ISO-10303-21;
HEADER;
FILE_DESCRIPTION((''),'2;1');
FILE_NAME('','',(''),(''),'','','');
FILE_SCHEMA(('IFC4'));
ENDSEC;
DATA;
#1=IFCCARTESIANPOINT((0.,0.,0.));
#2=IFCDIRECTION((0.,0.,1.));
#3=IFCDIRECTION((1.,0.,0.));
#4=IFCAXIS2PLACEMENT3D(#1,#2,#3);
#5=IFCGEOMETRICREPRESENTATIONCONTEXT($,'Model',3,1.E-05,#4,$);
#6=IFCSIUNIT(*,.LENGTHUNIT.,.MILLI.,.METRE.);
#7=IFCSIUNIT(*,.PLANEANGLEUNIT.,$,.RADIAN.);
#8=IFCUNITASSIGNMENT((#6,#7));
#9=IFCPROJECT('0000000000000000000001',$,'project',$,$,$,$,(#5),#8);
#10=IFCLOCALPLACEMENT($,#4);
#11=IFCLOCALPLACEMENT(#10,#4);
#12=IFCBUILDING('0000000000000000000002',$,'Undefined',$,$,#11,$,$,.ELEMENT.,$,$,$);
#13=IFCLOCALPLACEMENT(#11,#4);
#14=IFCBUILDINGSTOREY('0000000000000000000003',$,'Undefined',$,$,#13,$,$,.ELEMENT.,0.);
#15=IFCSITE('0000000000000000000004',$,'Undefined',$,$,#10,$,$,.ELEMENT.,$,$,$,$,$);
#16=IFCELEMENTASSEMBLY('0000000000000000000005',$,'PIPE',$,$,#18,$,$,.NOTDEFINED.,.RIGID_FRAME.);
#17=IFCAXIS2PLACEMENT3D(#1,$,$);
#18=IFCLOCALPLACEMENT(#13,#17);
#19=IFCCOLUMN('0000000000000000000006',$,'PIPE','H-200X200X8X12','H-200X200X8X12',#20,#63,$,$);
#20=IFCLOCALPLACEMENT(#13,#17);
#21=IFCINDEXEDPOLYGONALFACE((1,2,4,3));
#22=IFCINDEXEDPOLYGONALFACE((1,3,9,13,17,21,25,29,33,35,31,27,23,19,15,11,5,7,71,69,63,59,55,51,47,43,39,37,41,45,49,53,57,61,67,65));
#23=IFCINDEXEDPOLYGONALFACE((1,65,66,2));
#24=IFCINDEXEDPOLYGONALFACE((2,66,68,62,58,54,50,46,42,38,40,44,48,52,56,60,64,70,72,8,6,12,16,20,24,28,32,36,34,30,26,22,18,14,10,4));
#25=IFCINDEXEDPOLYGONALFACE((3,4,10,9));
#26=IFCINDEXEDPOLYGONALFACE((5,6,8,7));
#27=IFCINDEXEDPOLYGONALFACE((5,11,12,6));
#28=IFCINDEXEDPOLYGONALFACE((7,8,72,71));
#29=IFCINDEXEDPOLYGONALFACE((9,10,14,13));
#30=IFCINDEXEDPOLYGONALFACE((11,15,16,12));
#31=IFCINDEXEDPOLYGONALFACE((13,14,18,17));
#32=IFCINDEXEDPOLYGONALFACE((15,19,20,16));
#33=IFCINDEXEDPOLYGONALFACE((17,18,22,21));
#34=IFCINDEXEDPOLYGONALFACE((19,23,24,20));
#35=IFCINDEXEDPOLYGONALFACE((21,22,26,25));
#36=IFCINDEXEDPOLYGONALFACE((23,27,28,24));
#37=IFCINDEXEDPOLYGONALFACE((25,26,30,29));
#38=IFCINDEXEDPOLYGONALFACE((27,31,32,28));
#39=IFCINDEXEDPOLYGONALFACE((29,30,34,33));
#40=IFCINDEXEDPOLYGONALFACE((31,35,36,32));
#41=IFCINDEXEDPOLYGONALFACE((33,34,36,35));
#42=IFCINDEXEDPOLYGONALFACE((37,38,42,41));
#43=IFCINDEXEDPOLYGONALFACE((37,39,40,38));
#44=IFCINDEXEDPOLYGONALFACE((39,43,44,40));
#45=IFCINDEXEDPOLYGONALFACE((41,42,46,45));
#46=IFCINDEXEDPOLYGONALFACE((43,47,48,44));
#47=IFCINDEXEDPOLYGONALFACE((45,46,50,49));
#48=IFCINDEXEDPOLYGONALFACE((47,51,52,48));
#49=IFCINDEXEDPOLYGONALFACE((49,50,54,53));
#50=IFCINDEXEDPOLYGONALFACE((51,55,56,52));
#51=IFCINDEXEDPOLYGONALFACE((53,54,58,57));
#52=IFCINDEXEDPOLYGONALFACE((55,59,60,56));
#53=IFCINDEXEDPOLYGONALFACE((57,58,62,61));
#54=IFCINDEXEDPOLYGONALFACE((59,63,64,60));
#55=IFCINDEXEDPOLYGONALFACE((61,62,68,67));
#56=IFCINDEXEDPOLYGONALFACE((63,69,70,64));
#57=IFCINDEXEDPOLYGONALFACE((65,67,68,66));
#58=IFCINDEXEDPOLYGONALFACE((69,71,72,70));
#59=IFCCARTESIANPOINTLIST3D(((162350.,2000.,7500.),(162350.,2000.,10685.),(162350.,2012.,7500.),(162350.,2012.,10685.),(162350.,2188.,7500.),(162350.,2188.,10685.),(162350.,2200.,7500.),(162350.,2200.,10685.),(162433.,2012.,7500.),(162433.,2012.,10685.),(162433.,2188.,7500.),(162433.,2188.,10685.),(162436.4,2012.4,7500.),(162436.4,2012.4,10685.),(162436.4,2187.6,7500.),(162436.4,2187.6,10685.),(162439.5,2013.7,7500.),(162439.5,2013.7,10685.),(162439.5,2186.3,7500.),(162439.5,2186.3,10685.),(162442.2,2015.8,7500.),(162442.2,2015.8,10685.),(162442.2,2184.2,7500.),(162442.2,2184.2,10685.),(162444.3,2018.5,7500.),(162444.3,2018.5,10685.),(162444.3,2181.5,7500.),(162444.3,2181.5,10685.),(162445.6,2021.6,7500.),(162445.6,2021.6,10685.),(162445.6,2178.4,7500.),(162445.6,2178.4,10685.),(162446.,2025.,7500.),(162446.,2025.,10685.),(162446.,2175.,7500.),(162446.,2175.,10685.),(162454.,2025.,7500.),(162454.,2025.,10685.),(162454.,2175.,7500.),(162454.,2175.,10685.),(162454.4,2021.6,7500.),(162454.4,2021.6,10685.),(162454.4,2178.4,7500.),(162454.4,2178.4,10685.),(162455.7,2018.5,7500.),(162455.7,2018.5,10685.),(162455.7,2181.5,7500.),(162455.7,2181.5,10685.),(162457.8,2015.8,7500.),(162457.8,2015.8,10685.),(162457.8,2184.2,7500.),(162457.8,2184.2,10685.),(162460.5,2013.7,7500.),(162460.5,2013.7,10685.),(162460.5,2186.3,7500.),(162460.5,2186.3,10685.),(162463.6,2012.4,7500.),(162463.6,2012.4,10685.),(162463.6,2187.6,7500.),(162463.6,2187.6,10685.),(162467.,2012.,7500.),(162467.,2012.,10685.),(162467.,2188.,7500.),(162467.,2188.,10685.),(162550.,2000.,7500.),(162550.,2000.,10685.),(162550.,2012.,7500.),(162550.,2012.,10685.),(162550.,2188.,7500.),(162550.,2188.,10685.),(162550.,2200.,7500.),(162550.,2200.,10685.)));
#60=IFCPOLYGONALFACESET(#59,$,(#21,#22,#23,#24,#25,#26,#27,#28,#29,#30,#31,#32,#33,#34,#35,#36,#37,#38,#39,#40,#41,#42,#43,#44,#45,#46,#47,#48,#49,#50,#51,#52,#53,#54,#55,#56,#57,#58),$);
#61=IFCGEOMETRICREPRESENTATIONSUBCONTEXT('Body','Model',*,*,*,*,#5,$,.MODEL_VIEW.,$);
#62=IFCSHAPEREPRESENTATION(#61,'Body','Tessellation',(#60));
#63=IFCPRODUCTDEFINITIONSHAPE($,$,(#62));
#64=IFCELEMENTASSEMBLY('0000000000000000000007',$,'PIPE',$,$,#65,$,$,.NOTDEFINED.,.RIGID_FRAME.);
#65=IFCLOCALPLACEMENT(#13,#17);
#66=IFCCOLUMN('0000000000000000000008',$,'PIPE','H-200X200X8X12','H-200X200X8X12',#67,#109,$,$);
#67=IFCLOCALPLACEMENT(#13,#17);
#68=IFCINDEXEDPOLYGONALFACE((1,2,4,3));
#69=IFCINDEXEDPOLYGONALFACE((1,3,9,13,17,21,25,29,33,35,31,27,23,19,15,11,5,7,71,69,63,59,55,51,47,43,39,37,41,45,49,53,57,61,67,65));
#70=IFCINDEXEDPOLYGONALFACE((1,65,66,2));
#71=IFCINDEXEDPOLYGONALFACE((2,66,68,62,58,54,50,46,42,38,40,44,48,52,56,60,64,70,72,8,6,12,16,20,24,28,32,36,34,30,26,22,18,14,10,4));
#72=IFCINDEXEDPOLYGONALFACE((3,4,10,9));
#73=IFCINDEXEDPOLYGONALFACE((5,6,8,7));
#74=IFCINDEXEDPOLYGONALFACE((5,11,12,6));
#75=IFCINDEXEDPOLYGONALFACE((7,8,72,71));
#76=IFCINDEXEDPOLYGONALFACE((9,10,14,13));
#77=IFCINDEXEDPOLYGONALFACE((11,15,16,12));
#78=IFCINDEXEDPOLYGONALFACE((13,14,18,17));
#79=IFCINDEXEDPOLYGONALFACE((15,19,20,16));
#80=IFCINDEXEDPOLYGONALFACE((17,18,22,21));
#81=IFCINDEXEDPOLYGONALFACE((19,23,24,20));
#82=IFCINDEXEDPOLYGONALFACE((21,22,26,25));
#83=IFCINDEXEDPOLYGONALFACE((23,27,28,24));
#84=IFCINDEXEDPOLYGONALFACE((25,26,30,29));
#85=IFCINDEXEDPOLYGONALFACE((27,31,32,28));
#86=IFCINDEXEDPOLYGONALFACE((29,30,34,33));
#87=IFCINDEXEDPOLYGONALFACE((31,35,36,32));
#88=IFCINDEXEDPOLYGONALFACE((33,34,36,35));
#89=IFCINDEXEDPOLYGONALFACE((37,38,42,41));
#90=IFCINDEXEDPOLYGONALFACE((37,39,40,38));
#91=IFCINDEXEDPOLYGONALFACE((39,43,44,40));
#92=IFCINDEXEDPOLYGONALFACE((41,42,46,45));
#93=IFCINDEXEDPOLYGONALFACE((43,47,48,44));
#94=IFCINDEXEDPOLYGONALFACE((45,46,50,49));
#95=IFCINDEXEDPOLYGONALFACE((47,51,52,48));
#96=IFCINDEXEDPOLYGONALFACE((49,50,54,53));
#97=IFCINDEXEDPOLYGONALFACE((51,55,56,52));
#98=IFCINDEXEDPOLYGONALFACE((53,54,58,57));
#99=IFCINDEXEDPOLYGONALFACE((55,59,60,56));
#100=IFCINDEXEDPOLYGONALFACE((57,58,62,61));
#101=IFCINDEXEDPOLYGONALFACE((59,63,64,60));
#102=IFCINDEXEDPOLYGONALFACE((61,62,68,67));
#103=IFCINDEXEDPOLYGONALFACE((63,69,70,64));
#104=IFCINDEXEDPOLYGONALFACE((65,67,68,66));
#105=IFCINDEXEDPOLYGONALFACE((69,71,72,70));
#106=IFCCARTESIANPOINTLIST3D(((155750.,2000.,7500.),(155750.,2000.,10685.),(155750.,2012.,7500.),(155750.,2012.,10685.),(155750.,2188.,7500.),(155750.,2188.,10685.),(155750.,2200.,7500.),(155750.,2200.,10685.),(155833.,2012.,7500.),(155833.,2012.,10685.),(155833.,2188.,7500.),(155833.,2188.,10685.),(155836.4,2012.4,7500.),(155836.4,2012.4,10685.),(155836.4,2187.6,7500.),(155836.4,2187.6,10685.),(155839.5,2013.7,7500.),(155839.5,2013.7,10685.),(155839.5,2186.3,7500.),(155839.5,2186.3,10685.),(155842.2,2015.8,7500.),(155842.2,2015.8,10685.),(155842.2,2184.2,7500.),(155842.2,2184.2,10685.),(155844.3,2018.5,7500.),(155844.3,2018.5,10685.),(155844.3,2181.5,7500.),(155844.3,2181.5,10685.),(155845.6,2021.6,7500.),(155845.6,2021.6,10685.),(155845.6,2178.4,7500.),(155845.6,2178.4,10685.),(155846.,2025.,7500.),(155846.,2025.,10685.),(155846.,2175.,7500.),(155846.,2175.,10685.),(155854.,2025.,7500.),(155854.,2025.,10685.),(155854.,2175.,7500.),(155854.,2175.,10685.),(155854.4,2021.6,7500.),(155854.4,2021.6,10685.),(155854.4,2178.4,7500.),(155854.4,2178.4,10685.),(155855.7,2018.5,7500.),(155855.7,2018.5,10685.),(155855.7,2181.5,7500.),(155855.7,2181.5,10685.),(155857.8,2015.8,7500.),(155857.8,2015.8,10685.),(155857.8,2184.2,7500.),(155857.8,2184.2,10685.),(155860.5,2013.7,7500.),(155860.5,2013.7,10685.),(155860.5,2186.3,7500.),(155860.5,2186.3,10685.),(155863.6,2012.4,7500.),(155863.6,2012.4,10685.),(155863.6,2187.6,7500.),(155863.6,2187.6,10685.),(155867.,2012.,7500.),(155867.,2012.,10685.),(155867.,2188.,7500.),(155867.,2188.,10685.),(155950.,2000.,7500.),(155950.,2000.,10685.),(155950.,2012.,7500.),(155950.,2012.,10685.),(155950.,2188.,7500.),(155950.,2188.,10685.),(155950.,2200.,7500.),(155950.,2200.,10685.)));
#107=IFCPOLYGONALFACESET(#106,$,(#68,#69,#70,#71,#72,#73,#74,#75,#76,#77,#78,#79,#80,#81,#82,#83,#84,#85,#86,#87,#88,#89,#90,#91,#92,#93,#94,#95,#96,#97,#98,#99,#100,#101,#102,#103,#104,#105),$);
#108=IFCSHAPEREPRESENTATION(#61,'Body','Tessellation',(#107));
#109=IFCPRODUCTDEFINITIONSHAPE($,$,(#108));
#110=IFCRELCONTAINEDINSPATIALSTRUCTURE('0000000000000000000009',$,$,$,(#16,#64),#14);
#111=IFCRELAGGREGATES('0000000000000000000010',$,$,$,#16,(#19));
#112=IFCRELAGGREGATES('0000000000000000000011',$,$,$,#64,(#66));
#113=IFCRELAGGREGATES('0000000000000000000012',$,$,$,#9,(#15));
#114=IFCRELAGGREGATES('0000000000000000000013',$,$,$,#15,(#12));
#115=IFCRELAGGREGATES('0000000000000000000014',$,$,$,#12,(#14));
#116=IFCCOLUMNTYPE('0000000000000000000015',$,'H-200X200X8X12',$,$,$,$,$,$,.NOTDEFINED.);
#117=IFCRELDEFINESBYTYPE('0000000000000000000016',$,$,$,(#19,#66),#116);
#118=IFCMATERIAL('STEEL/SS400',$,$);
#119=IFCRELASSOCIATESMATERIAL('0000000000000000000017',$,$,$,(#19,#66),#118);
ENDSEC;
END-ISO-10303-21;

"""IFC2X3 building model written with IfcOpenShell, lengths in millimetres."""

from ifc_helpers import new_model, si_unit, frame, origin_with_axes, origin_2d_with_axis, place, context, subcontext, project, spatial, i_section, extrude, clip, halfspace, material, type_object, element, aggregate, save


model = new_model("IFC2X3")

# Units and contexts
model_context = context("Model", 3, precision=1e-05, world=origin_with_axes())
body_context = subcontext(model_context, "Body", "Model", "MODEL_VIEW")
ifc_project = project(units=[si_unit("LENGTHUNIT", "METRE", prefix="MILLI"), si_unit("PLANEANGLEUNIT", "RADIAN")], contexts=[model_context])

# Site, building, storey
site_placement = place(None, origin_with_axes())
site = spatial("IfcSite", under=ifc_project, at=site_placement, Name="Undefined", CompositionType="ELEMENT")
building_placement = place(site_placement, origin_with_axes())
building = spatial("IfcBuilding", under=site, at=building_placement, Name="Undefined", CompositionType="ELEMENT")
storey_placement = place(building_placement, origin_with_axes())
storey = spatial("IfcBuildingStorey", under=building, at=storey_placement, Name="Undefined", CompositionType="ELEMENT", Elevation=0.0)

# Element assemblies, columns
assembly_1_placement = place(storey_placement, origin_with_axes())
assembly_1 = element("IfcElementAssembly", 1, at=assembly_1_placement, inside=storey, Name="PIPE", AssemblyPlace="NOTDEFINED", PredefinedType="RIGID_FRAME")
ifc_material_1 = material(Name="STEEL/SS400")
column_type = type_object("IfcColumnType", Name="H-200X200X8X12", PredefinedType="NOTDEFINED")
column_1_placement = place(assembly_1_placement, frame((162450.0, 2100.0, 7500.0), z_axis=(0.0, 0.0, 1.0), x_axis=(0.0, 1.0, 0.0)))
column_1 = element("IfcColumn", 2, at=column_1_placement, type_object=column_type, material=ifc_material_1, Name="PIPE", Description="H-200X200X8X12", ObjectType="H-200X200X8X12", context=body_context, shape_type="Clipping", body=[
    clip(extrude(i_section(OverallWidth=200.0, OverallDepth=200.0, WebThickness=8.0, FlangeThickness=12.0, FilletRadius=13.0, at=origin_2d_with_axis()), frame((0.0, 0.0, 3185.0), z_axis=(0.0, 0.0, -1.0), x_axis=(0.0, 1.0, 0.0)), (0.0, 0.0, 1.0), 3185.0), halfspace(frame((-100.0, 0.0, 3185.0), z_axis=(0.0, 0.0, -1.0), x_axis=(0.0, -1.0, 0.0)), True)),
])
aggregate(assembly_1, [column_1])
assembly_2_placement = place(storey_placement, origin_with_axes())
assembly_2 = element("IfcElementAssembly", 3, at=assembly_2_placement, inside=storey, Name="PIPE", AssemblyPlace="NOTDEFINED", PredefinedType="RIGID_FRAME")
column_2_placement = place(assembly_2_placement, frame((155850.0, 2100.0, 7500.0), z_axis=(0.0, 0.0, 1.0), x_axis=(0.0, 1.0, 0.0)))
column_2 = element("IfcColumn", 4, at=column_2_placement, type_object=column_type, material=ifc_material_1, Name="PIPE", Description="H-200X200X8X12", ObjectType="H-200X200X8X12", context=body_context, shape_type="Clipping", body=[
    clip(extrude(i_section(OverallWidth=200.0, OverallDepth=200.0, WebThickness=8.0, FlangeThickness=12.0, FilletRadius=13.0, at=origin_2d_with_axis()), frame((0.0, 0.0, 3185.0), z_axis=(0.0, 0.0, -1.0), x_axis=(0.0, 1.0, 0.0)), (0.0, 0.0, 1.0), 3185.0), halfspace(frame((-100.0, 0.0, 3185.0), z_axis=(0.0, 0.0, -1.0), x_axis=(0.0, -1.0, 0.0)), True)),
])
aggregate(assembly_2, [column_2])

save(model, "model.ifc")
